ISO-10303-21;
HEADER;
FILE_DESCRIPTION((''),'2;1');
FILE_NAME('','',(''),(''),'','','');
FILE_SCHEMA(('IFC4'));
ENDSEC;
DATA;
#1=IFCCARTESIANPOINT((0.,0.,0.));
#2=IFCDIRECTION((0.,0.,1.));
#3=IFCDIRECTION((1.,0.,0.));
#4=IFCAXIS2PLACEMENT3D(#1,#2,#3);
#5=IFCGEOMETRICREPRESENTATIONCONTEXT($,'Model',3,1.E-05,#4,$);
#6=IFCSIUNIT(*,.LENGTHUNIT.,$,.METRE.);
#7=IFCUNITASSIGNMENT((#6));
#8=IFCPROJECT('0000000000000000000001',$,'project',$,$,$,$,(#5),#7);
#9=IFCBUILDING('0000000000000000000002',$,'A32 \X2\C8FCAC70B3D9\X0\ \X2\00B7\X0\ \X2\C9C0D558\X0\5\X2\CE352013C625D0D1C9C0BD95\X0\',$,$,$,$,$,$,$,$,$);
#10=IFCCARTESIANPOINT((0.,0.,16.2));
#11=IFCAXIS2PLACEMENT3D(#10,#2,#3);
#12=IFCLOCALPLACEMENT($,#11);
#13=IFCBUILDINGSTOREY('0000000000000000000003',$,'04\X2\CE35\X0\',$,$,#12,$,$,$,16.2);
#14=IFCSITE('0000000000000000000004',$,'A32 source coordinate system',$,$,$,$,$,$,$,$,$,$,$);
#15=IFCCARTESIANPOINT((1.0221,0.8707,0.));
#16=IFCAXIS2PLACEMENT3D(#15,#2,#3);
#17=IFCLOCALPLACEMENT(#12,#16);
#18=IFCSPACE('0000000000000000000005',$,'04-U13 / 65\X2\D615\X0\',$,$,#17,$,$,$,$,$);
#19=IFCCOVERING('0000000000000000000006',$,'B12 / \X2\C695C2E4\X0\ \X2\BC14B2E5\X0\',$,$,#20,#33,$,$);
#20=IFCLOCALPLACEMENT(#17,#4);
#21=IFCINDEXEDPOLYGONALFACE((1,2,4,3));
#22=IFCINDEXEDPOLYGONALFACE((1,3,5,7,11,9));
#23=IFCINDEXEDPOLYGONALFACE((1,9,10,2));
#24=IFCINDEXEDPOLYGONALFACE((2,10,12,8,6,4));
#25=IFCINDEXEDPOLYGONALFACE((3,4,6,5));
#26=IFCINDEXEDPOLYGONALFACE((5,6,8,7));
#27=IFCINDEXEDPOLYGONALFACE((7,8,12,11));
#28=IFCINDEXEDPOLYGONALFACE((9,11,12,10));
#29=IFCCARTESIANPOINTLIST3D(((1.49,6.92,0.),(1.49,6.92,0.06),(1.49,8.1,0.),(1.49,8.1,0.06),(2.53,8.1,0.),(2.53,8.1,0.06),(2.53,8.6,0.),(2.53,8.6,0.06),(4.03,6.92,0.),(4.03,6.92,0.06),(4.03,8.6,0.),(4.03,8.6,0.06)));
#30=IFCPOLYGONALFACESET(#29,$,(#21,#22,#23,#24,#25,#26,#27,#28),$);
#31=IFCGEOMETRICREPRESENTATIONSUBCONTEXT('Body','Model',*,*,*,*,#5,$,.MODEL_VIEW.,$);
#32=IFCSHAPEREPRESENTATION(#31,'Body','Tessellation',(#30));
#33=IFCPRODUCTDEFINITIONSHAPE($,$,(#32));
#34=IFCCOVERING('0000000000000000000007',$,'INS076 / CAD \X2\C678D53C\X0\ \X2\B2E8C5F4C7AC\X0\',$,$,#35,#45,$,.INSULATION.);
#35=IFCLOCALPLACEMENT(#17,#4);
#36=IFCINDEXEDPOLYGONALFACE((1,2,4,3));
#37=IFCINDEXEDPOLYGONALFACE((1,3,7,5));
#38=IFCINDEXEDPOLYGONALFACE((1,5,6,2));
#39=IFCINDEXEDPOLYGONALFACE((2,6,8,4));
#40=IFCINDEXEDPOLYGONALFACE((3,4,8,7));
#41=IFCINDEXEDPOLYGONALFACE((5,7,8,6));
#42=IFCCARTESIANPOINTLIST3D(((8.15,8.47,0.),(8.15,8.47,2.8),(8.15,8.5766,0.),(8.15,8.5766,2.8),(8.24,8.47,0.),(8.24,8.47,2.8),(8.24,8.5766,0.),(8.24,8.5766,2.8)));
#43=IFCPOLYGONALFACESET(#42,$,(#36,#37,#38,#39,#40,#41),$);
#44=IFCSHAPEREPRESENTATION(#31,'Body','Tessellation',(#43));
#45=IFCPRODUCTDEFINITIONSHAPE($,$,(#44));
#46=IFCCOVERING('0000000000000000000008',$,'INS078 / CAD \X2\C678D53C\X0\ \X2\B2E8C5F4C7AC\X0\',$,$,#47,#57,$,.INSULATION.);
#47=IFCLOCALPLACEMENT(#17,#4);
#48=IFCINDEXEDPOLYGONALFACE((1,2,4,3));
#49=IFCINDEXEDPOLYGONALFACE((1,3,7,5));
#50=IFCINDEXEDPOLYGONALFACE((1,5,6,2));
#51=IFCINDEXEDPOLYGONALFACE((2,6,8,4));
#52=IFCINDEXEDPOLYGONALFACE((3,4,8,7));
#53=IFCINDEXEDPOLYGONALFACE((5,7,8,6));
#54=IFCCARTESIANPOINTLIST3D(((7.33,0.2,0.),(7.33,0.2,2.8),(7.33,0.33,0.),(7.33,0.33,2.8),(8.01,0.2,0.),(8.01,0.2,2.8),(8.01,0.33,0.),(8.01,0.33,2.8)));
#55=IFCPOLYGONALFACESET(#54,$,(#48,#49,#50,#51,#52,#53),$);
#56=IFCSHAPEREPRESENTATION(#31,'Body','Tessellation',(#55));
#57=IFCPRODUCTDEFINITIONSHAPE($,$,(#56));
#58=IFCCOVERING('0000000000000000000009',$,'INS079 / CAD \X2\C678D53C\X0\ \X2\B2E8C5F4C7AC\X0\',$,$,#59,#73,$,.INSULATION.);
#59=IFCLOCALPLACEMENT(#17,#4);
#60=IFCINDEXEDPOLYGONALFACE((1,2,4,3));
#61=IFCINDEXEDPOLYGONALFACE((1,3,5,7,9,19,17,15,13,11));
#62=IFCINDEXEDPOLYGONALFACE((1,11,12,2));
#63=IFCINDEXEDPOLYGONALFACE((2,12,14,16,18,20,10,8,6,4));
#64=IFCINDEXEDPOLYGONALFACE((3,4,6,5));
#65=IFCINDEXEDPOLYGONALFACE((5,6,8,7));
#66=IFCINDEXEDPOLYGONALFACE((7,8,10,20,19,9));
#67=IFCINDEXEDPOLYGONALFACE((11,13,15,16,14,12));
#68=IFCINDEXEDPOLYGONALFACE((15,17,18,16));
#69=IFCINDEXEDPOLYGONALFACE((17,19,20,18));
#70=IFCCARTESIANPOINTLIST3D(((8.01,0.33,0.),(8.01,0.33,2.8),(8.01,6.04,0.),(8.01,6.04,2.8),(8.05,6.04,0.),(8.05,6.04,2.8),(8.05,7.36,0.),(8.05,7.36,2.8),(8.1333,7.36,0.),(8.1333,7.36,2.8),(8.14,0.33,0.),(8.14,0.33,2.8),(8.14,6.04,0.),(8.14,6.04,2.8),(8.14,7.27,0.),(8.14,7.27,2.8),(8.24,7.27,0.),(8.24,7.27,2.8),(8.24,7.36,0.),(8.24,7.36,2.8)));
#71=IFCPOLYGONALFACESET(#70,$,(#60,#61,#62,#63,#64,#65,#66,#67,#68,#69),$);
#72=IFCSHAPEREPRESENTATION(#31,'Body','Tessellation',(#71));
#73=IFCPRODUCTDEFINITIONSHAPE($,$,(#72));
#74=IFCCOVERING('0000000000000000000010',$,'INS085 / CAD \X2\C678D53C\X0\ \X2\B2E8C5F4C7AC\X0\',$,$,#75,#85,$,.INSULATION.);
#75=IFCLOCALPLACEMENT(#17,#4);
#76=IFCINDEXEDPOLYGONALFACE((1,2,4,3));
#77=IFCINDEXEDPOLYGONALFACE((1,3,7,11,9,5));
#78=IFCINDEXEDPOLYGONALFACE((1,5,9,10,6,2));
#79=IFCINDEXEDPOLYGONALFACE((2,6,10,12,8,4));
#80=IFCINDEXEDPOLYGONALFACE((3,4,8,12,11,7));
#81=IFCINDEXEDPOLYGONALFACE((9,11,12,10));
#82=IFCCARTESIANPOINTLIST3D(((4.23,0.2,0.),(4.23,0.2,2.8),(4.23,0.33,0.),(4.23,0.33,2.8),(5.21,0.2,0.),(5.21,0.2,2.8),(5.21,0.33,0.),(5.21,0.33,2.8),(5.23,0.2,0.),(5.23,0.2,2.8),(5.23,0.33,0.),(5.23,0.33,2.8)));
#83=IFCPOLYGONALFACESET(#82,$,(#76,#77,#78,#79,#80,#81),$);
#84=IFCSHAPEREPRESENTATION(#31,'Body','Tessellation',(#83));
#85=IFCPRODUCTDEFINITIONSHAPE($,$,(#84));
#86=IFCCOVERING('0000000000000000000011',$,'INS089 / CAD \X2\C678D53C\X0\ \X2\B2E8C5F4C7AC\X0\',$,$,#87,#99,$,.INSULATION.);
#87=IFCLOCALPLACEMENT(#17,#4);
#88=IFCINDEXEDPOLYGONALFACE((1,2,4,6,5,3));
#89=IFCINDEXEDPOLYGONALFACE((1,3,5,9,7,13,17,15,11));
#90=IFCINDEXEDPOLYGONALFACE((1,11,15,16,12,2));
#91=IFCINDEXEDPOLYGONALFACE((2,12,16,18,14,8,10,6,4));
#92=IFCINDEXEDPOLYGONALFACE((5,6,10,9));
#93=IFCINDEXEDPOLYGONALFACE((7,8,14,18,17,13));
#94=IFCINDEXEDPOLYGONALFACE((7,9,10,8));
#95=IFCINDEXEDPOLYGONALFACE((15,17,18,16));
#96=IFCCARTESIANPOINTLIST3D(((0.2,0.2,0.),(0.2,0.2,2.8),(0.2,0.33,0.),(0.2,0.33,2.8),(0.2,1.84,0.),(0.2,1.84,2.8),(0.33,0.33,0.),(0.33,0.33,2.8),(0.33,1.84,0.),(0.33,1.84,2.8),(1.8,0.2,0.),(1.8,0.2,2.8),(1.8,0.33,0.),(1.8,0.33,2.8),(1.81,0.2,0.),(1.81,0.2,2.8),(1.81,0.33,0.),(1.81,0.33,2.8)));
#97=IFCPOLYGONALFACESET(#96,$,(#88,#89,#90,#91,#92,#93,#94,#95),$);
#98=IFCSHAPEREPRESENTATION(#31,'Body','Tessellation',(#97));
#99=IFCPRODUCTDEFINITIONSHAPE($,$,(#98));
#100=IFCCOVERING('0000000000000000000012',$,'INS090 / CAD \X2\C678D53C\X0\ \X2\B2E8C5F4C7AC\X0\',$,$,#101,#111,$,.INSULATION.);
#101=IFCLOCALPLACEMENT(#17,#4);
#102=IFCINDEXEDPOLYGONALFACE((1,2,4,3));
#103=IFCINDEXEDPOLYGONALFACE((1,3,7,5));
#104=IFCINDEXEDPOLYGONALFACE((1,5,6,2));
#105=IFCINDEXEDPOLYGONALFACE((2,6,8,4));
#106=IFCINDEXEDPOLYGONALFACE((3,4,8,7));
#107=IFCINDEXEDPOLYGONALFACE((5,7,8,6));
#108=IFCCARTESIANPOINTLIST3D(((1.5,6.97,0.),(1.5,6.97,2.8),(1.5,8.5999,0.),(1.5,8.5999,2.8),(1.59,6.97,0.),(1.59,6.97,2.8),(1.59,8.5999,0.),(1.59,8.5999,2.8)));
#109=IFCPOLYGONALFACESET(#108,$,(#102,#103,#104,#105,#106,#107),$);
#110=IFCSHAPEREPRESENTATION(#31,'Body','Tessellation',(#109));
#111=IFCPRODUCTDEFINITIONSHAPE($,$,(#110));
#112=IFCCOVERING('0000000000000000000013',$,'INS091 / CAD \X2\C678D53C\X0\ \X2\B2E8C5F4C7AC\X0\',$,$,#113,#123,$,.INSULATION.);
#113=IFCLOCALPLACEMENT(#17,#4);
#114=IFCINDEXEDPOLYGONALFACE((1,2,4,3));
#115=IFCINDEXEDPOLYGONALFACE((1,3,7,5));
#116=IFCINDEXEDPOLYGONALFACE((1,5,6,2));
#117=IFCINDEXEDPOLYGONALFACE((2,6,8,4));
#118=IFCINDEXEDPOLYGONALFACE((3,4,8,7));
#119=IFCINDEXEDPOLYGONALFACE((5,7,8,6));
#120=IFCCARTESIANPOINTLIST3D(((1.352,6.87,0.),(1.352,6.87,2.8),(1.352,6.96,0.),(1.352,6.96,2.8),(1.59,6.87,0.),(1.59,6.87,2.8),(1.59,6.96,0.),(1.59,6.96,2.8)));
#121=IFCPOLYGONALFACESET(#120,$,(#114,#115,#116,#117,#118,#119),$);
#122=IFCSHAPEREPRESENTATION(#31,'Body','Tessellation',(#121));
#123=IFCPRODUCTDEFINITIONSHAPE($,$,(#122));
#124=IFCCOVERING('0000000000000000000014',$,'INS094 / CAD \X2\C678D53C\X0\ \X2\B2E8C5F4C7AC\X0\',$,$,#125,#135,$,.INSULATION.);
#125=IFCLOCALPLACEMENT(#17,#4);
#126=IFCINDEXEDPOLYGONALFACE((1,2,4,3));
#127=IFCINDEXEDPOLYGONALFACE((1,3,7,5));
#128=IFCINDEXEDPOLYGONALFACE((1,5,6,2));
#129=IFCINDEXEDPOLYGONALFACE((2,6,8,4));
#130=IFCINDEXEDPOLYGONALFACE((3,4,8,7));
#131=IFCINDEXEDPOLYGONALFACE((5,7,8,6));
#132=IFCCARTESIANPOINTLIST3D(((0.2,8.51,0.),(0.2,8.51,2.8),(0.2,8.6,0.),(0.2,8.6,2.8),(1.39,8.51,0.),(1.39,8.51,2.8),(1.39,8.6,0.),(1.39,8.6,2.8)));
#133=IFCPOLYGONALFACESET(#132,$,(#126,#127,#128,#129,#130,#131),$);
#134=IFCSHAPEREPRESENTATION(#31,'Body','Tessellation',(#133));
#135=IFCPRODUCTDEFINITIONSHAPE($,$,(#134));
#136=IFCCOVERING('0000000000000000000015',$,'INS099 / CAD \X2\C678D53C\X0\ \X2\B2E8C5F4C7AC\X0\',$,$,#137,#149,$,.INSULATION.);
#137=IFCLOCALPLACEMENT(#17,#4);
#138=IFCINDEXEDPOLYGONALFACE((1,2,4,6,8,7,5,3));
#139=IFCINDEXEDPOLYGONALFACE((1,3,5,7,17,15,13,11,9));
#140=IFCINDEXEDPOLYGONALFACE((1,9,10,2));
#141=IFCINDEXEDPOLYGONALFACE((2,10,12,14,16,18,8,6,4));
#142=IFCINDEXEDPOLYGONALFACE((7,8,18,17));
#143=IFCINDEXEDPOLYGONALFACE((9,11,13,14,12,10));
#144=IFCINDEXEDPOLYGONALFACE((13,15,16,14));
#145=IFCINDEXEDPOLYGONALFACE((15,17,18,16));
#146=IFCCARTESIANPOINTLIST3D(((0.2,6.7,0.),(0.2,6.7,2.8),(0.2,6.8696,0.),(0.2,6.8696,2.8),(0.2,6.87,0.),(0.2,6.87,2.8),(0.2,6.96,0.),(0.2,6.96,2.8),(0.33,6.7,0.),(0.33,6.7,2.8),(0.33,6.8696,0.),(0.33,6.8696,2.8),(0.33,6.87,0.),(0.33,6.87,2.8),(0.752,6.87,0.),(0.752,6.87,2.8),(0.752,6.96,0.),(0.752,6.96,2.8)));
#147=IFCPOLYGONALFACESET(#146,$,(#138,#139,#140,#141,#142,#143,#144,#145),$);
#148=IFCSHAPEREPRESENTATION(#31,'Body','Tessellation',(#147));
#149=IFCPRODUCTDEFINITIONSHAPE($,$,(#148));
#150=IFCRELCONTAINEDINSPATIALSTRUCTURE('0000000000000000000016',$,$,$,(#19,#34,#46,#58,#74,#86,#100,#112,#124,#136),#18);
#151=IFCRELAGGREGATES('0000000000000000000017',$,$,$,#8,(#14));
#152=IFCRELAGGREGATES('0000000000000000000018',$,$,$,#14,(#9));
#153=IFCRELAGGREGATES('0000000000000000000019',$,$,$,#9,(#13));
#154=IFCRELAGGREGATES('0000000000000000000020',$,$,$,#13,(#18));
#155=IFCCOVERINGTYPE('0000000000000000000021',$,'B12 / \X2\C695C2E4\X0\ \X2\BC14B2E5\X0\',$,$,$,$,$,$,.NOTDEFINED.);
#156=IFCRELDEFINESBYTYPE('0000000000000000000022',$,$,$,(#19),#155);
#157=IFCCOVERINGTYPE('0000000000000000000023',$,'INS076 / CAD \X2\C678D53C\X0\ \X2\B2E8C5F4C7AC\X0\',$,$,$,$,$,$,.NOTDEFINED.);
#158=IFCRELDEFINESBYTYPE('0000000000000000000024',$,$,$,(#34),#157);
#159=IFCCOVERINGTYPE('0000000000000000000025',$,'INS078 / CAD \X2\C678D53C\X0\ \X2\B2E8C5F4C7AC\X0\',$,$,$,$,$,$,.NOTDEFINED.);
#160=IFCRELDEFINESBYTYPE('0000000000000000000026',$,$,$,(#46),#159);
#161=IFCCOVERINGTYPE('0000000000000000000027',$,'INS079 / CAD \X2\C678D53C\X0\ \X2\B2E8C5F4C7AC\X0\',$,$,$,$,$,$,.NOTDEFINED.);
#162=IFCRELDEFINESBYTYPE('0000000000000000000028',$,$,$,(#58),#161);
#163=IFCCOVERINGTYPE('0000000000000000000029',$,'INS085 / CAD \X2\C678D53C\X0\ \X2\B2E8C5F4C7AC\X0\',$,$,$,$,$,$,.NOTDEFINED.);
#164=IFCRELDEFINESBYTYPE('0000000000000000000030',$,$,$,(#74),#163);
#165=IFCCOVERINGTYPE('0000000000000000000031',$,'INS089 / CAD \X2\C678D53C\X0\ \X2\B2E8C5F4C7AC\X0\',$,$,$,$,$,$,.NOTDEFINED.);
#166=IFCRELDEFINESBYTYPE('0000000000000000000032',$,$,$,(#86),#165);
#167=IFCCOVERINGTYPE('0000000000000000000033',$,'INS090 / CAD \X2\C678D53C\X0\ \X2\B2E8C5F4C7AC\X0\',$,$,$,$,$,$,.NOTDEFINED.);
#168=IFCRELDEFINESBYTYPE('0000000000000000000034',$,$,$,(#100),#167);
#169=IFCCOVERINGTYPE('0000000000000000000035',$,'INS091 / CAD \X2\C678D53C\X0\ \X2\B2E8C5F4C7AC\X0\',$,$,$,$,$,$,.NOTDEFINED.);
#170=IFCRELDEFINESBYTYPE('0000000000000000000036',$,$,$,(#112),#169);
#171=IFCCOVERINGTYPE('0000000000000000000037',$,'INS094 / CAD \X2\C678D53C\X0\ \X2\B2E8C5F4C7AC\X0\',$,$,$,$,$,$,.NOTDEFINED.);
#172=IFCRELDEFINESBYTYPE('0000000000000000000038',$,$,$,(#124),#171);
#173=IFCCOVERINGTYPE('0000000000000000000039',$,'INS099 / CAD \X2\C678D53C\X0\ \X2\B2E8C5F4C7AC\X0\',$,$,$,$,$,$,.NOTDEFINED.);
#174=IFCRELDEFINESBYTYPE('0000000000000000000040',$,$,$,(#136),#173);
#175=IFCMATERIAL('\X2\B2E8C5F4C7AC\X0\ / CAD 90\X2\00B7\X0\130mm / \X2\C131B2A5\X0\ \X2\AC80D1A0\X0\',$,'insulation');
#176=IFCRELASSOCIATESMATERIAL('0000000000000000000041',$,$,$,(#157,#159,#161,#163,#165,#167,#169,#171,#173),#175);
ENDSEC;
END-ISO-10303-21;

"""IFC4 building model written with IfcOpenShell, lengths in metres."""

from ifc_helpers import new_model, si_unit, frame, origin, origin_with_axes, place, context, subcontext, project, spatial, polyline, outline, extrude, source, transform, mapped, material, type_object, type_shapes, element, save


model = new_model("IFC4")

# Units and contexts
model_context = context("Model", 3, precision=1e-05, world=origin_with_axes())
body_context = subcontext(model_context, "Body", "Model", "MODEL_VIEW")
ifc_project = project(units=[si_unit("LENGTHUNIT", "METRE")], contexts=[model_context])

# Site, building, storey
site = spatial("IfcSite", under=ifc_project, Name="A32 source coordinate system")
building = spatial("IfcBuilding", under=site, Name="A32 주거동 · 지하5층–옥탑지붕")
storey_placement = place(None, frame((0.0, 0.0, 16.2), z_axis=(0.0, 0.0, 1.0), x_axis=(1.0, 0.0, 0.0)))
storey = spatial("IfcBuildingStorey", under=building, at=storey_placement, Name="04층", Elevation=16.2)

# Shared definitions
space_placement = place(storey_placement, frame((1.0221, 0.8707, 0.0), z_axis=(0.0, 0.0, 1.0), x_axis=(1.0, 0.0, 0.0)))
space = spatial("IfcSpace", under=storey, at=space_placement, Name="04-U13 / 65형")

# Coverings
covering_type_1 = type_object("IfcCoveringType", Name="B12 / 욕실 바닥", PredefinedType="NOTDEFINED")
shared_shape_1 = source(origin(), body_context, "Body", "SweptSolid", [
    extrude(outline(polyline([(2.53, 8.6), (4.03, 8.6), (4.03, 6.92), (1.49, 6.92), (1.49, 8.1), (2.53, 8.1), (2.53, 8.6)])), origin(), (0.0, 0.0, 1.0), 0.06),
])
type_shapes(covering_type_1, [shared_shape_1])
covering_1_placement = place(space_placement, origin_with_axes())
element("IfcCovering", 1, at=covering_1_placement, inside=space, type_object=covering_type_1, Name="B12 / 욕실 바닥", context=body_context, shape_type="MappedRepresentation", body=[
    mapped(shared_shape_1, transform((0.0, 0.0, 0.0), scale=1.0)),
])
ifc_material = material(Name="단열재 / CAD 90·130mm / 성능 검토", Category="insulation")
covering_type_2 = type_object("IfcCoveringType", Name="INS076 / CAD 외피 단열재", PredefinedType="NOTDEFINED", material=ifc_material)
shared_shape_2 = source(origin(), body_context, "Body", "SweptSolid", [
    extrude(outline(polyline([(8.24, 8.5766), (8.24, 8.47), (8.15, 8.47), (8.15, 8.5766), (8.24, 8.5766)])), origin(), (0.0, 0.0, 1.0), 2.8),
])
type_shapes(covering_type_2, [shared_shape_2])
covering_2_placement = place(space_placement, origin_with_axes())
element("IfcCovering", 2, at=covering_2_placement, inside=space, type_object=covering_type_2, Name="INS076 / CAD 외피 단열재", PredefinedType="INSULATION", context=body_context, shape_type="MappedRepresentation", body=[
    mapped(shared_shape_2, transform((0.0, 0.0, 0.0), scale=1.0)),
])
covering_type_3 = type_object("IfcCoveringType", Name="INS078 / CAD 외피 단열재", PredefinedType="NOTDEFINED", material=ifc_material)
shared_shape_3 = source(origin(), body_context, "Body", "SweptSolid", [
    extrude(outline(polyline([(8.01, 0.2), (7.33, 0.2), (7.33, 0.33), (8.01, 0.33), (8.01, 0.2)])), origin(), (0.0, 0.0, 1.0), 2.8),
])
type_shapes(covering_type_3, [shared_shape_3])
covering_3_placement = place(space_placement, origin_with_axes())
element("IfcCovering", 3, at=covering_3_placement, inside=space, type_object=covering_type_3, Name="INS078 / CAD 외피 단열재", PredefinedType="INSULATION", context=body_context, shape_type="MappedRepresentation", body=[
    mapped(shared_shape_3, transform((0.0, 0.0, 0.0), scale=1.0)),
])
covering_type_4 = type_object("IfcCoveringType", Name="INS079 / CAD 외피 단열재", PredefinedType="NOTDEFINED", material=ifc_material)
shared_shape_4 = source(origin(), body_context, "Body", "SweptSolid", [
    extrude(outline(polyline([(8.24, 7.27), (8.14, 7.27), (8.14, 6.04), (8.14, 0.33), (8.01, 0.33), (8.01, 6.04), (8.05, 6.04), (8.05, 7.36), (8.1333, 7.36), (8.24, 7.36), (8.24, 7.27)])), origin(), (0.0, 0.0, 1.0), 2.8),
])
type_shapes(covering_type_4, [shared_shape_4])
covering_4_placement = place(space_placement, origin_with_axes())
element("IfcCovering", 4, at=covering_4_placement, inside=space, type_object=covering_type_4, Name="INS079 / CAD 외피 단열재", PredefinedType="INSULATION", context=body_context, shape_type="MappedRepresentation", body=[
    mapped(shared_shape_4, transform((0.0, 0.0, 0.0), scale=1.0)),
])
covering_type_5 = type_object("IfcCoveringType", Name="INS085 / CAD 외피 단열재", PredefinedType="NOTDEFINED", material=ifc_material)
shared_shape_5 = source(origin(), body_context, "Body", "SweptSolid", [
    extrude(outline(polyline([(4.23, 0.2), (4.23, 0.33), (5.21, 0.33), (5.23, 0.33), (5.23, 0.2), (5.21, 0.2), (4.23, 0.2)])), origin(), (0.0, 0.0, 1.0), 2.8),
])
type_shapes(covering_type_5, [shared_shape_5])
covering_5_placement = place(space_placement, origin_with_axes())
element("IfcCovering", 5, at=covering_5_placement, inside=space, type_object=covering_type_5, Name="INS085 / CAD 외피 단열재", PredefinedType="INSULATION", context=body_context, shape_type="MappedRepresentation", body=[
    mapped(shared_shape_5, transform((0.0, 0.0, 0.0), scale=1.0)),
])
covering_type_6 = type_object("IfcCoveringType", Name="INS089 / CAD 외피 단열재", PredefinedType="NOTDEFINED", material=ifc_material)
shared_shape_6 = source(origin(), body_context, "Body", "SweptSolid", [
    extrude(outline(polyline([(0.2, 0.33), (0.2, 1.84), (0.33, 1.84), (0.33, 0.33), (1.8, 0.33), (1.81, 0.33), (1.81, 0.2), (1.8, 0.2), (0.2, 0.2), (0.2, 0.33)])), origin(), (0.0, 0.0, 1.0), 2.8),
])
type_shapes(covering_type_6, [shared_shape_6])
covering_6_placement = place(space_placement, origin_with_axes())
element("IfcCovering", 6, at=covering_6_placement, inside=space, type_object=covering_type_6, Name="INS089 / CAD 외피 단열재", PredefinedType="INSULATION", context=body_context, shape_type="MappedRepresentation", body=[
    mapped(shared_shape_6, transform((0.0, 0.0, 0.0), scale=1.0)),
])
covering_type_7 = type_object("IfcCoveringType", Name="INS090 / CAD 외피 단열재", PredefinedType="NOTDEFINED", material=ifc_material)
shared_shape_7 = source(origin(), body_context, "Body", "SweptSolid", [
    extrude(outline(polyline([(1.59, 6.97), (1.5, 6.97), (1.5, 8.5999), (1.59, 8.5999), (1.59, 6.97)])), origin(), (0.0, 0.0, 1.0), 2.8),
])
type_shapes(covering_type_7, [shared_shape_7])
covering_7_placement = place(space_placement, origin_with_axes())
element("IfcCovering", 7, at=covering_7_placement, inside=space, type_object=covering_type_7, Name="INS090 / CAD 외피 단열재", PredefinedType="INSULATION", context=body_context, shape_type="MappedRepresentation", body=[
    mapped(shared_shape_7, transform((0.0, 0.0, 0.0), scale=1.0)),
])
covering_type_8 = type_object("IfcCoveringType", Name="INS091 / CAD 외피 단열재", PredefinedType="NOTDEFINED", material=ifc_material)
shared_shape_8 = source(origin(), body_context, "Body", "SweptSolid", [
    extrude(outline(polyline([(1.59, 6.96), (1.59, 6.87), (1.352, 6.87), (1.352, 6.96), (1.59, 6.96)])), origin(), (0.0, 0.0, 1.0), 2.8),
])
type_shapes(covering_type_8, [shared_shape_8])
covering_8_placement = place(space_placement, origin_with_axes())
element("IfcCovering", 8, at=covering_8_placement, inside=space, type_object=covering_type_8, Name="INS091 / CAD 외피 단열재", PredefinedType="INSULATION", context=body_context, shape_type="MappedRepresentation", body=[
    mapped(shared_shape_8, transform((0.0, 0.0, 0.0), scale=1.0)),
])
covering_type_9 = type_object("IfcCoveringType", Name="INS094 / CAD 외피 단열재", PredefinedType="NOTDEFINED", material=ifc_material)
shared_shape_9 = source(origin(), body_context, "Body", "SweptSolid", [
    extrude(outline(polyline([(1.39, 8.51), (0.2, 8.51), (0.2, 8.6), (1.39, 8.6), (1.39, 8.51)])), origin(), (0.0, 0.0, 1.0), 2.8),
])
type_shapes(covering_type_9, [shared_shape_9])
covering_9_placement = place(space_placement, origin_with_axes())
element("IfcCovering", 9, at=covering_9_placement, inside=space, type_object=covering_type_9, Name="INS094 / CAD 외피 단열재", PredefinedType="INSULATION", context=body_context, shape_type="MappedRepresentation", body=[
    mapped(shared_shape_9, transform((0.0, 0.0, 0.0), scale=1.0)),
])
covering_type_10 = type_object("IfcCoveringType", Name="INS099 / CAD 외피 단열재", PredefinedType="NOTDEFINED", material=ifc_material)
shared_shape_10 = source(origin(), body_context, "Body", "SweptSolid", [
    extrude(outline(polyline([(0.2, 6.8696), (0.2, 6.87), (0.2, 6.96), (0.752, 6.96), (0.752, 6.87), (0.33, 6.87), (0.33, 6.8696), (0.33, 6.7), (0.2, 6.7), (0.2, 6.8696)])), origin(), (0.0, 0.0, 1.0), 2.8),
])
type_shapes(covering_type_10, [shared_shape_10])
covering_10_placement = place(space_placement, origin_with_axes())
element("IfcCovering", 10, at=covering_10_placement, inside=space, type_object=covering_type_10, Name="INS099 / CAD 외피 단열재", PredefinedType="INSULATION", context=body_context, shape_type="MappedRepresentation", body=[
    mapped(shared_shape_10, transform((0.0, 0.0, 0.0), scale=1.0)),
])

save(model, "model.ifc")
